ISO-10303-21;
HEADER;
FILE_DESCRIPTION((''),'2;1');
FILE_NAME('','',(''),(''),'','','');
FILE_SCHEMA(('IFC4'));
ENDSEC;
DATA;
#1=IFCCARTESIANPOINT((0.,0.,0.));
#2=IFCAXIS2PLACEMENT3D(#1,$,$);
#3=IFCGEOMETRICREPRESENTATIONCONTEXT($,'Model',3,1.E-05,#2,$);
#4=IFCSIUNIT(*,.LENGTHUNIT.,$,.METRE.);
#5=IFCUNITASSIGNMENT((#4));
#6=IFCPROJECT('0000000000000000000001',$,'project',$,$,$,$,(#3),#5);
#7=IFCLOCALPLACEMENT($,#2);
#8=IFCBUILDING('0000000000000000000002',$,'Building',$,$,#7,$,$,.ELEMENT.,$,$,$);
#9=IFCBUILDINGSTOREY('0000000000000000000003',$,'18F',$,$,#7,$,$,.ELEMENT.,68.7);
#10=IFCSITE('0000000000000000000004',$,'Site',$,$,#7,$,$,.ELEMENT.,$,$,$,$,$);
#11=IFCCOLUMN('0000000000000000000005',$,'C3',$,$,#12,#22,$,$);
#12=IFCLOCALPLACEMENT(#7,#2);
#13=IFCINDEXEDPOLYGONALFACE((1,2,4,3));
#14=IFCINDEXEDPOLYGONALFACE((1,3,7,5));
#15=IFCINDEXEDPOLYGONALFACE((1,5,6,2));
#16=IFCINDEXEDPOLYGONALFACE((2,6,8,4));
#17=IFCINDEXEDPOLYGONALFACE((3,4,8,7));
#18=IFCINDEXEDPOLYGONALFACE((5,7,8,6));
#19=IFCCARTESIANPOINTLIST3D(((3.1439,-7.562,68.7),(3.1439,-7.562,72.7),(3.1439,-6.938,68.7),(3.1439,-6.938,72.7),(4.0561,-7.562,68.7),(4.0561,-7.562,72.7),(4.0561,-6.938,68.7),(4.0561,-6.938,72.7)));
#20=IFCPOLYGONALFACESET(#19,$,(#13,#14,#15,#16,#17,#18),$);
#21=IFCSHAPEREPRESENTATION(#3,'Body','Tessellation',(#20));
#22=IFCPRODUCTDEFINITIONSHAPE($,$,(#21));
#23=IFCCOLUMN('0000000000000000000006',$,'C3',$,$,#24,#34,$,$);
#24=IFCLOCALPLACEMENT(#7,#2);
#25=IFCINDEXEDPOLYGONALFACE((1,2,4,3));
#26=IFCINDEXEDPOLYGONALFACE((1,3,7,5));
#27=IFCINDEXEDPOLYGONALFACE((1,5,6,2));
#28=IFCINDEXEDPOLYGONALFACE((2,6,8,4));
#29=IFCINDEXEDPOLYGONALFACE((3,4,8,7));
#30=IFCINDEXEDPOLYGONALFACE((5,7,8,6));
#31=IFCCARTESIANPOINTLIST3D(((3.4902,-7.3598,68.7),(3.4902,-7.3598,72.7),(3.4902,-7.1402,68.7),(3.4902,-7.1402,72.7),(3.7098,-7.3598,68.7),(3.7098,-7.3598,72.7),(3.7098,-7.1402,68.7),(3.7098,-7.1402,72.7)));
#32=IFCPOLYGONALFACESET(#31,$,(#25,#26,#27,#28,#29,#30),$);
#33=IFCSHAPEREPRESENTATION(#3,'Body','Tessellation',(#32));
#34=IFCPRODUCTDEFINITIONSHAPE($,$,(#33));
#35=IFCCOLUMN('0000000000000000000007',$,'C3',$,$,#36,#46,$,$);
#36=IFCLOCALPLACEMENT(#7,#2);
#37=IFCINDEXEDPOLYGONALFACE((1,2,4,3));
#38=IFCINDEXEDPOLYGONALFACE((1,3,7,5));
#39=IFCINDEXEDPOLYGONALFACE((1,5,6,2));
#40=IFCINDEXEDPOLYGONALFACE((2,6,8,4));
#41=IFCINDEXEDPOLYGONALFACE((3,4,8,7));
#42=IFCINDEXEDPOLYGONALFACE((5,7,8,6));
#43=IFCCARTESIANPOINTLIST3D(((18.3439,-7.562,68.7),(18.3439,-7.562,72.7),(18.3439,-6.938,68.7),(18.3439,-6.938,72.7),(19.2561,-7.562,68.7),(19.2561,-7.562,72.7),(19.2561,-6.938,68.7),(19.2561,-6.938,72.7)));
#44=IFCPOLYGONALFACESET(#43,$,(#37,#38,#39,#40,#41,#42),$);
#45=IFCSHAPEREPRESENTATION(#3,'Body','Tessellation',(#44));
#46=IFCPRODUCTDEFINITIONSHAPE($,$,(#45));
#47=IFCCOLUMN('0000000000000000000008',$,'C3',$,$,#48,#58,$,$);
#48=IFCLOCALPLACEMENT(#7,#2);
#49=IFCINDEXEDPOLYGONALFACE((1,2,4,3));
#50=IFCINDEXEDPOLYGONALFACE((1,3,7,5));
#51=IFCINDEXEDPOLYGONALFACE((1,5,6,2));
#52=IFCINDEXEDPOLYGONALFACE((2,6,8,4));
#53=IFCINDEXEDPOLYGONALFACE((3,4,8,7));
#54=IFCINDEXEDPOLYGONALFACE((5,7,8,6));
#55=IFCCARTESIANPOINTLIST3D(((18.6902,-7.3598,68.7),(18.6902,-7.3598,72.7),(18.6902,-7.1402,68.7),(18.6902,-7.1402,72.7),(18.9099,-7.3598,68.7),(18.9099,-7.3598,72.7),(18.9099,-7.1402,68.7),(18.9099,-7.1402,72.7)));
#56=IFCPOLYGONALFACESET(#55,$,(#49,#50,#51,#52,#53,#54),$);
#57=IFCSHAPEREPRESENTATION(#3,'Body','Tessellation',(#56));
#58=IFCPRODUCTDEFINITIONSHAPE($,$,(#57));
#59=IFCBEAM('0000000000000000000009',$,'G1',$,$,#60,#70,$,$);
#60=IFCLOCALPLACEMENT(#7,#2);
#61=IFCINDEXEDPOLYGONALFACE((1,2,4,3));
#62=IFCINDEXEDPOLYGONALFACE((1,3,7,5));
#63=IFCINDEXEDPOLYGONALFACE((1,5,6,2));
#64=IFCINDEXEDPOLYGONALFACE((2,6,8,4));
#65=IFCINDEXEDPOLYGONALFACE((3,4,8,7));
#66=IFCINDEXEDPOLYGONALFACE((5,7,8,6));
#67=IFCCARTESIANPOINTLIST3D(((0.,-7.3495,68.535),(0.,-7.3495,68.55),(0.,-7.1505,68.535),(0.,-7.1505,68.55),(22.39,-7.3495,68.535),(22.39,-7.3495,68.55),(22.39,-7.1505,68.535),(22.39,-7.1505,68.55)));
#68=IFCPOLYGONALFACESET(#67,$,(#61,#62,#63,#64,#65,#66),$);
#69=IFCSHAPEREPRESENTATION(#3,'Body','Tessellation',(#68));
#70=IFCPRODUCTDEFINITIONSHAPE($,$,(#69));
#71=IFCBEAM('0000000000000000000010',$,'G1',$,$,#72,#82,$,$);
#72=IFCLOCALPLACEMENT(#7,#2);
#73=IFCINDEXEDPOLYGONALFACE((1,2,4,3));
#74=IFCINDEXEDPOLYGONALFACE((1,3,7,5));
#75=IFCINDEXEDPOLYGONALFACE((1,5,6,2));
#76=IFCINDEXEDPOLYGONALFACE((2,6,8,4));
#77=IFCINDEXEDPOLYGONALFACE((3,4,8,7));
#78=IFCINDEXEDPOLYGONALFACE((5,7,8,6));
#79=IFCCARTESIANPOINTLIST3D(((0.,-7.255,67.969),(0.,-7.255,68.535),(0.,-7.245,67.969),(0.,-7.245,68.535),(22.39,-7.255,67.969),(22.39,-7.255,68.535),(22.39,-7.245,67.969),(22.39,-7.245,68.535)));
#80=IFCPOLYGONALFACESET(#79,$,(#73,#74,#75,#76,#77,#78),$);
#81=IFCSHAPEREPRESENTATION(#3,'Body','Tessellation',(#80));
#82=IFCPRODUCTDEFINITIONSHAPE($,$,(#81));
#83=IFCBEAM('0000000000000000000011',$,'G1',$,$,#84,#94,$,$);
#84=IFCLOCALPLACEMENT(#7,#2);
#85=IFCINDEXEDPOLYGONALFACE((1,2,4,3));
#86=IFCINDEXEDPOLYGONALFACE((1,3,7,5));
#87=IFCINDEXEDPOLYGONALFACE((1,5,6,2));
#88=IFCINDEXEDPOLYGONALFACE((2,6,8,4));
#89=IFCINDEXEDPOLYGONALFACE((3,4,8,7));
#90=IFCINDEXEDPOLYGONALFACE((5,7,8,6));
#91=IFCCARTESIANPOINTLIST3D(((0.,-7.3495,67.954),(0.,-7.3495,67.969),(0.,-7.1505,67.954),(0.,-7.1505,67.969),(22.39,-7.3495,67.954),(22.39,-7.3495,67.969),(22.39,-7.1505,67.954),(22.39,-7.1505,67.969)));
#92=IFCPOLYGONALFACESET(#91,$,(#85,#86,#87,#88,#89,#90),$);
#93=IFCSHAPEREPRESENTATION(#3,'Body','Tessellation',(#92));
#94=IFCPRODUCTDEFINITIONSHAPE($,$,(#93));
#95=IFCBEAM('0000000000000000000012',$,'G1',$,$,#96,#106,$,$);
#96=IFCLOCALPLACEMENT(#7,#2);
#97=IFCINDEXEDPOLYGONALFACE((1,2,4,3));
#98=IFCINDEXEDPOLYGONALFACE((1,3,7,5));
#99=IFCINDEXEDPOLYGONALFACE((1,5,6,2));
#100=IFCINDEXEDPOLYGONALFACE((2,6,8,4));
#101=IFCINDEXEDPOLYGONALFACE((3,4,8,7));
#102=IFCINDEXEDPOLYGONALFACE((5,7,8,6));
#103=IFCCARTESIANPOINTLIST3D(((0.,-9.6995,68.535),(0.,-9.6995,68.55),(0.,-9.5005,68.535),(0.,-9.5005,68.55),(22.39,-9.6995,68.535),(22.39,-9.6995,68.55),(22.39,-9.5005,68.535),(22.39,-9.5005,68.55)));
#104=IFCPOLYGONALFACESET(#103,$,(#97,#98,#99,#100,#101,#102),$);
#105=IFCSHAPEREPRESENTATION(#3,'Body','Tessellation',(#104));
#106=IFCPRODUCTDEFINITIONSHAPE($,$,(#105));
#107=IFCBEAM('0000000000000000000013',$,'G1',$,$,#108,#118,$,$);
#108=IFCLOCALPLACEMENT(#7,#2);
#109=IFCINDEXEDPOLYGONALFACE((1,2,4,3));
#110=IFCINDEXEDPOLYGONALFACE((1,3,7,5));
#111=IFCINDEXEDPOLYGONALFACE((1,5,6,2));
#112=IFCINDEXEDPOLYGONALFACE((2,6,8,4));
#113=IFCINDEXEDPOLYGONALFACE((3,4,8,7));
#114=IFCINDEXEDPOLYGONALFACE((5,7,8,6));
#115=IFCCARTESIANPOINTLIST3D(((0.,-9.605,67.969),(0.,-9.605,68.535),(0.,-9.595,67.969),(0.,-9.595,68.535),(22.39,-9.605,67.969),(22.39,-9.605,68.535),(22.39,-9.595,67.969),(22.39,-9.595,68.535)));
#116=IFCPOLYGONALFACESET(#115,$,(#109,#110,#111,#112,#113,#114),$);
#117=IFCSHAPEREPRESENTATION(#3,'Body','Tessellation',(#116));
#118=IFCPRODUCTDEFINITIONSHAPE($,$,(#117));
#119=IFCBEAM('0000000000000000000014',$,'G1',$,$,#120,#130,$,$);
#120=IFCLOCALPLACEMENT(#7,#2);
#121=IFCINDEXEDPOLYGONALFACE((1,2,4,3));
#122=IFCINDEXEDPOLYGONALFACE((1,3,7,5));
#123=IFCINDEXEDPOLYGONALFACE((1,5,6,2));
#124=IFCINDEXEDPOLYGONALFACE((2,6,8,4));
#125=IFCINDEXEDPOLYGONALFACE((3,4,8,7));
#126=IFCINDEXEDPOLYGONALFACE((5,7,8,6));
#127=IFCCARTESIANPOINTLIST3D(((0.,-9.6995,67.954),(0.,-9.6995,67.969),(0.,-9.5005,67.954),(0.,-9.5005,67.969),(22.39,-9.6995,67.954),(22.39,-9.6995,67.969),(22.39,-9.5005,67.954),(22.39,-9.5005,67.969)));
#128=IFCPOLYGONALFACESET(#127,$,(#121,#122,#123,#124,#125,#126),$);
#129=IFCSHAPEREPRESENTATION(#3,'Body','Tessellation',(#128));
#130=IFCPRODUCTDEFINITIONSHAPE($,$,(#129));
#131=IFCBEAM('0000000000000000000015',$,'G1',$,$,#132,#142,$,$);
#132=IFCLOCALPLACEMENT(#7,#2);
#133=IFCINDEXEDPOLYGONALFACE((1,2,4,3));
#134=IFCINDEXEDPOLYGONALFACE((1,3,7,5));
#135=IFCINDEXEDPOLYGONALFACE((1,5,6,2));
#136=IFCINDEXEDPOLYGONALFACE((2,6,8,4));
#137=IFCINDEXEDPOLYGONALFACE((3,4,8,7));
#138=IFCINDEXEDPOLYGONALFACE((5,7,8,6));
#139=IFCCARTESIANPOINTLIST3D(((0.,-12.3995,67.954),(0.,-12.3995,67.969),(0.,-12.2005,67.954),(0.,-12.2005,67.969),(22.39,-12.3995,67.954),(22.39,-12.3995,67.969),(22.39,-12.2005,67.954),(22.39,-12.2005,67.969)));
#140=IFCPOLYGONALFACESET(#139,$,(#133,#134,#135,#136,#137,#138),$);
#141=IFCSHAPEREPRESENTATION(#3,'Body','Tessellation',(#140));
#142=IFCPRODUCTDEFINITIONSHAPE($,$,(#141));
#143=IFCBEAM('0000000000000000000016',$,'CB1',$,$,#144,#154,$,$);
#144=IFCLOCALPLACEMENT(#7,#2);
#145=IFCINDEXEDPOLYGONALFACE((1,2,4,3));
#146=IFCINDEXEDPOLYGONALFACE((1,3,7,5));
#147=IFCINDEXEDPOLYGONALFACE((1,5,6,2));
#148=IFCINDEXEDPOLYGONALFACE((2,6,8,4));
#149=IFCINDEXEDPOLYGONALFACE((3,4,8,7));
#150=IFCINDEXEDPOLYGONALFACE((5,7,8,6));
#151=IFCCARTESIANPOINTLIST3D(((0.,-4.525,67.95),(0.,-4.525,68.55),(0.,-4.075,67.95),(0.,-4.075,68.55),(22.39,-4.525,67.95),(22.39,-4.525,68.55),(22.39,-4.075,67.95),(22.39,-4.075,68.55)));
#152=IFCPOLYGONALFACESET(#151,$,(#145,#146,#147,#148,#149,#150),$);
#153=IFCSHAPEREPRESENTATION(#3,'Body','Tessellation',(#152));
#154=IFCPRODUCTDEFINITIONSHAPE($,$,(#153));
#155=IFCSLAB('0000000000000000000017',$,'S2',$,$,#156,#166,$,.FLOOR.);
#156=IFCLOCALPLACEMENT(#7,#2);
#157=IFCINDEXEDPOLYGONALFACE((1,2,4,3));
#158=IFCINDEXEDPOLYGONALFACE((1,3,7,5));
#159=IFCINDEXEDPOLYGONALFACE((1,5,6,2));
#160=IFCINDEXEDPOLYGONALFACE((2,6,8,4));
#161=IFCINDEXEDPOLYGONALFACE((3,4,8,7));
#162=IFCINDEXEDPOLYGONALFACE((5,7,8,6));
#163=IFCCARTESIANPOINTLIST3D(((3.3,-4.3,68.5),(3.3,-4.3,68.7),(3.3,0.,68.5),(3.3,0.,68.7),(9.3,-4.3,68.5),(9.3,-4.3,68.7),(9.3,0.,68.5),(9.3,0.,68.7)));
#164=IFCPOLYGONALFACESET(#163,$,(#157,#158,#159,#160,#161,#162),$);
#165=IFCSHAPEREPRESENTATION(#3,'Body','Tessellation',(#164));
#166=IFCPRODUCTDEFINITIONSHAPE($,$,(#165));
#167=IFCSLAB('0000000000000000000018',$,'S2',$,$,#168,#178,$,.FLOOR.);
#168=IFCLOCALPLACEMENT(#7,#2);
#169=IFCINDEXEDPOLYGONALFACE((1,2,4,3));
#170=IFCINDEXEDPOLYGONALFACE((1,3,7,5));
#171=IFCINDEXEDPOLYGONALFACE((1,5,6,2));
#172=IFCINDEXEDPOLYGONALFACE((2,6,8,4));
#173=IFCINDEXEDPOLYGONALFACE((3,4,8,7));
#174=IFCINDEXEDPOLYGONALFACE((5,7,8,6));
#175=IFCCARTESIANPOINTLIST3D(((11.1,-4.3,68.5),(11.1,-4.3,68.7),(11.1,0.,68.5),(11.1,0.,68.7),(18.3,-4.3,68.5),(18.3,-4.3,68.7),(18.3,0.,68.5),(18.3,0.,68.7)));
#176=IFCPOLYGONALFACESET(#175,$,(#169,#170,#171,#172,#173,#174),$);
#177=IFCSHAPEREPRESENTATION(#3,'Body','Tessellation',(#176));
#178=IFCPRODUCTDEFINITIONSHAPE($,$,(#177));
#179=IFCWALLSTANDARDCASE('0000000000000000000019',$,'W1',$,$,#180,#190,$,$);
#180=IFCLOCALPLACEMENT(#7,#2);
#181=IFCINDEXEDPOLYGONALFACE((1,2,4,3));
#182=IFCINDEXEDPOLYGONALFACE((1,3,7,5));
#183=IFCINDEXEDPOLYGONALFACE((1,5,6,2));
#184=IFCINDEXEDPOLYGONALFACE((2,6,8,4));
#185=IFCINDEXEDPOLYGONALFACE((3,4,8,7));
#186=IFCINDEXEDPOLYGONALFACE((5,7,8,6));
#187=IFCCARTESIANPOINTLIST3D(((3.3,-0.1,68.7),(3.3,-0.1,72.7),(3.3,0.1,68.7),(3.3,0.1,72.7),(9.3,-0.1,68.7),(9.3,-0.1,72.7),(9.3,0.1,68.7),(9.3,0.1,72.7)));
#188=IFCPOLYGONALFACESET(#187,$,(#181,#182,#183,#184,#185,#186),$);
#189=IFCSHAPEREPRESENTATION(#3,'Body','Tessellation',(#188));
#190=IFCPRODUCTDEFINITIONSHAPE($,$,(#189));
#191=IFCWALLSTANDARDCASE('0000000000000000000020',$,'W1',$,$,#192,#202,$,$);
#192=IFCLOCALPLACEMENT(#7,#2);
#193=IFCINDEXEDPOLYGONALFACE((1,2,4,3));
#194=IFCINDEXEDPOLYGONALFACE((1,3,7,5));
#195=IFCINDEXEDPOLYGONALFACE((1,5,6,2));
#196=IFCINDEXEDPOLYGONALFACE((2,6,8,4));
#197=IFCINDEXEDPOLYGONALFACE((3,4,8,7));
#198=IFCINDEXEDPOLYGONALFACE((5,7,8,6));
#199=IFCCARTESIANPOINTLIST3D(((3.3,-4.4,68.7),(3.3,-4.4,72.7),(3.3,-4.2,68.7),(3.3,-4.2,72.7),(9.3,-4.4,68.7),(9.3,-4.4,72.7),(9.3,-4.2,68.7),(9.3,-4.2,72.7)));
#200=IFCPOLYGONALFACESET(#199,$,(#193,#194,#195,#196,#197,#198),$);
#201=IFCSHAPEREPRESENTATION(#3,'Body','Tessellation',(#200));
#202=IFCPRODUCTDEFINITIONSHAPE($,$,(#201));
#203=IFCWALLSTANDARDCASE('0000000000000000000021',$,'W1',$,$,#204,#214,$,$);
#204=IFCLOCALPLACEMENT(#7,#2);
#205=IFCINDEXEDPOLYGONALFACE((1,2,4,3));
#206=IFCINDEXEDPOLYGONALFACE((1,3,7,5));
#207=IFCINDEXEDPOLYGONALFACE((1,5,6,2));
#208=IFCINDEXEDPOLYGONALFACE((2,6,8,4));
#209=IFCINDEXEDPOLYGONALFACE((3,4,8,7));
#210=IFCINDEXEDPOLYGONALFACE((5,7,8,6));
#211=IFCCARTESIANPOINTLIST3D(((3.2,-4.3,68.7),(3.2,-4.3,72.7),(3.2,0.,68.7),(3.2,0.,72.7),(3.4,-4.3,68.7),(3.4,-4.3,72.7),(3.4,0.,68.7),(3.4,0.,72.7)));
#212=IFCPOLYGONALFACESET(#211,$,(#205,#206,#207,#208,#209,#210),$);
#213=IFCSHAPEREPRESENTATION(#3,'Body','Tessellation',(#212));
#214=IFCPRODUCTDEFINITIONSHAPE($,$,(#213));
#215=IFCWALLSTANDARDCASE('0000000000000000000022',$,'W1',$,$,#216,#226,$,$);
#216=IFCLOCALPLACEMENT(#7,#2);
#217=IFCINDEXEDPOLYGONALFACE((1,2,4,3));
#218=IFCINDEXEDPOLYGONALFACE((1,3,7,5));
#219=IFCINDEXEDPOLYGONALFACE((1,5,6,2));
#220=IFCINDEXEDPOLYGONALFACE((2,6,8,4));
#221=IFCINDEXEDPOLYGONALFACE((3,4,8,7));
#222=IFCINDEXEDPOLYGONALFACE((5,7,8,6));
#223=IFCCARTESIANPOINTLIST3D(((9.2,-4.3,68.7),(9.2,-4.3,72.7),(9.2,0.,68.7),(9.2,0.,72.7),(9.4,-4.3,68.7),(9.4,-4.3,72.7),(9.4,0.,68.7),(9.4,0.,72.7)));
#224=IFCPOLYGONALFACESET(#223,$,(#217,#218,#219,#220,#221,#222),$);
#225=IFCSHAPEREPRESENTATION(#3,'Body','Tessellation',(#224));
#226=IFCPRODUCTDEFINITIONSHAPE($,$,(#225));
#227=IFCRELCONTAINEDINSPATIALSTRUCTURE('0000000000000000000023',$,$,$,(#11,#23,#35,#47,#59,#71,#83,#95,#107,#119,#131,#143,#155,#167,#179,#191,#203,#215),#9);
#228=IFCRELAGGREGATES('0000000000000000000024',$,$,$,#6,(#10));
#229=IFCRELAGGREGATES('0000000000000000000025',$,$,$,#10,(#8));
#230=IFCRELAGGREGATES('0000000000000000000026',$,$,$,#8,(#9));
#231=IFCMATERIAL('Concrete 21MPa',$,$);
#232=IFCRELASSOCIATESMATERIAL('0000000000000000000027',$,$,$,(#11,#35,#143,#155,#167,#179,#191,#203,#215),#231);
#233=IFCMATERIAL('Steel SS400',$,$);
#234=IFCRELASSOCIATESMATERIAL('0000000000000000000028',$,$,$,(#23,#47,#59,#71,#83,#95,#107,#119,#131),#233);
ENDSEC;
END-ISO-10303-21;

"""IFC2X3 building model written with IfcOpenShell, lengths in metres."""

from ifc_helpers import new_model, si_unit, frame, origin, origin_2d, place, context, project, spatial, rectangle, extrude, material, element, save


model = new_model("IFC2X3")

# Units and contexts
model_context = context("Model", 3, precision=1e-05, world=origin())
ifc_project = project(units=[si_unit("LENGTHUNIT", "METRE")], contexts=[model_context])

# Site, building, storey
placement = place(None, origin())
site = spatial("IfcSite", under=ifc_project, at=placement, Name="Site", CompositionType="ELEMENT")
building = spatial("IfcBuilding", under=site, at=placement, Name="Building", CompositionType="ELEMENT")
storey = spatial("IfcBuildingStorey", under=building, at=placement, Name="18F", CompositionType="ELEMENT", Elevation=68.7)

# Columns
ifc_material_1 = material(Name="Concrete 21MPa")
column_1_placement = place(None, frame((3.6, -7.25, 68.7)))
element("IfcColumn", 1, at=column_1_placement, inside=storey, material=ifc_material_1, Name="C3", context=model_context, shape_type="SweptSolid", body=[
    extrude(rectangle(XDim=0.9121, YDim=0.6241, at=origin_2d()), origin(), (0.0, 0.0, 1.0), 4.0),
])
ifc_material_2 = material(Name="Steel SS400")
column_2_placement = place(None, frame((3.6, -7.25, 68.7)))
element("IfcColumn", 2, at=column_2_placement, inside=storey, material=ifc_material_2, Name="C3", context=model_context, shape_type="SweptSolid", body=[
    extrude(rectangle(XDim=0.2197, YDim=0.2197, at=origin_2d()), origin(), (0.0, 0.0, 1.0), 4.0),
])
column_3_placement = place(None, frame((18.8, -7.25, 68.7)))
element("IfcColumn", 3, at=column_3_placement, inside=storey, material=ifc_material_1, Name="C3", context=model_context, shape_type="SweptSolid", body=[
    extrude(rectangle(XDim=0.9121, YDim=0.6241, at=origin_2d()), origin(), (0.0, 0.0, 1.0), 4.0),
])
column_4_placement = place(None, frame((18.8, -7.25, 68.7)))
element("IfcColumn", 4, at=column_4_placement, inside=storey, material=ifc_material_2, Name="C3", context=model_context, shape_type="SweptSolid", body=[
    extrude(rectangle(XDim=0.2197, YDim=0.2197, at=origin_2d()), origin(), (0.0, 0.0, 1.0), 4.0),
])

# Beams
beam_1_placement = place(None, frame((11.195, -7.25, 68.535)))
element("IfcBeam", 5, at=beam_1_placement, inside=storey, material=ifc_material_2, Name="G1", context=model_context, shape_type="SweptSolid", body=[
    extrude(rectangle(XDim=22.39, YDim=0.199, at=origin_2d()), origin(), (0.0, 0.0, 1.0), 0.015),
])
beam_2_placement = place(None, frame((11.195, -7.25, 67.969)))
element("IfcBeam", 6, at=beam_2_placement, inside=storey, material=ifc_material_2, Name="G1", context=model_context, shape_type="SweptSolid", body=[
    extrude(rectangle(XDim=22.39, YDim=0.01, at=origin_2d()), origin(), (0.0, 0.0, 1.0), 0.566),
])
for number, where, name in (
    (7, (11.195, -7.25, 67.954), "G1"),
    (8, (11.195, -9.6, 68.535), "G1"),
):
    element("IfcBeam", number, at=place(None, frame(where)), inside=storey, material=ifc_material_2, Name=name, context=model_context, shape_type="SweptSolid", body=[
        extrude(rectangle(XDim=22.39, YDim=0.199, at=origin_2d()), origin(), (0.0, 0.0, 1.0), 0.015),
    ])
beam_3_placement = place(None, frame((11.195, -9.6, 67.969)))
element("IfcBeam", 9, at=beam_3_placement, inside=storey, material=ifc_material_2, Name="G1", context=model_context, shape_type="SweptSolid", body=[
    extrude(rectangle(XDim=22.39, YDim=0.01, at=origin_2d()), origin(), (0.0, 0.0, 1.0), 0.566),
])
for number, where, name in (
    (10, (11.195, -9.6, 67.954), "G1"),
    (11, (11.195, -12.3, 67.954), "G1"),
):
    element("IfcBeam", number, at=place(None, frame(where)), inside=storey, material=ifc_material_2, Name=name, context=model_context, shape_type="SweptSolid", body=[
        extrude(rectangle(XDim=22.39, YDim=0.199, at=origin_2d()), origin(), (0.0, 0.0, 1.0), 0.015),
    ])
beam_4_placement = place(None, frame((11.195, -4.3, 67.95)))
element("IfcBeam", 12, at=beam_4_placement, inside=storey, material=ifc_material_1, Name="CB1", context=model_context, shape_type="SweptSolid", body=[
    extrude(rectangle(XDim=22.39, YDim=0.45, at=origin_2d()), origin(), (0.0, 0.0, 1.0), 0.6),
])

# Slabs
slab_1_placement = place(None, frame((6.3, -2.15, 68.5)))
element("IfcSlab", 13, at=slab_1_placement, inside=storey, material=ifc_material_1, Name="S2", PredefinedType="FLOOR", context=model_context, shape_type="SweptSolid", body=[
    extrude(rectangle(XDim=6.0, YDim=4.3, at=origin_2d()), origin(), (0.0, 0.0, 1.0), 0.2),
])
slab_2_placement = place(None, frame((14.7, -2.15, 68.5)))
element("IfcSlab", 14, at=slab_2_placement, inside=storey, material=ifc_material_1, Name="S2", PredefinedType="FLOOR", context=model_context, shape_type="SweptSolid", body=[
    extrude(rectangle(XDim=7.2, YDim=4.3, at=origin_2d()), origin(), (0.0, 0.0, 1.0), 0.2),
])

# Walls
for number, where, name in (
    (15, (6.3, 0.0, 68.7), "W1"),
    (16, (6.3, -4.3, 68.7), "W1"),
):
    element("IfcWallStandardCase", number, at=place(None, frame(where)), inside=storey, material=ifc_material_1, Name=name, context=model_context, shape_type="SweptSolid", body=[
        extrude(rectangle(XDim=6.0, YDim=0.2, at=origin_2d()), origin(), (0.0, 0.0, 1.0), 4.0),
    ])
for number, where, name in (
    (17, (3.3, -2.15, 68.7), "W1"),
    (18, (9.3, -2.15, 68.7), "W1"),
):
    element("IfcWallStandardCase", number, at=place(None, frame(where)), inside=storey, material=ifc_material_1, Name=name, context=model_context, shape_type="SweptSolid", body=[
        extrude(rectangle(XDim=0.2, YDim=4.3, at=origin_2d()), origin(), (0.0, 0.0, 1.0), 4.0),
    ])

save(model, "model.ifc")
